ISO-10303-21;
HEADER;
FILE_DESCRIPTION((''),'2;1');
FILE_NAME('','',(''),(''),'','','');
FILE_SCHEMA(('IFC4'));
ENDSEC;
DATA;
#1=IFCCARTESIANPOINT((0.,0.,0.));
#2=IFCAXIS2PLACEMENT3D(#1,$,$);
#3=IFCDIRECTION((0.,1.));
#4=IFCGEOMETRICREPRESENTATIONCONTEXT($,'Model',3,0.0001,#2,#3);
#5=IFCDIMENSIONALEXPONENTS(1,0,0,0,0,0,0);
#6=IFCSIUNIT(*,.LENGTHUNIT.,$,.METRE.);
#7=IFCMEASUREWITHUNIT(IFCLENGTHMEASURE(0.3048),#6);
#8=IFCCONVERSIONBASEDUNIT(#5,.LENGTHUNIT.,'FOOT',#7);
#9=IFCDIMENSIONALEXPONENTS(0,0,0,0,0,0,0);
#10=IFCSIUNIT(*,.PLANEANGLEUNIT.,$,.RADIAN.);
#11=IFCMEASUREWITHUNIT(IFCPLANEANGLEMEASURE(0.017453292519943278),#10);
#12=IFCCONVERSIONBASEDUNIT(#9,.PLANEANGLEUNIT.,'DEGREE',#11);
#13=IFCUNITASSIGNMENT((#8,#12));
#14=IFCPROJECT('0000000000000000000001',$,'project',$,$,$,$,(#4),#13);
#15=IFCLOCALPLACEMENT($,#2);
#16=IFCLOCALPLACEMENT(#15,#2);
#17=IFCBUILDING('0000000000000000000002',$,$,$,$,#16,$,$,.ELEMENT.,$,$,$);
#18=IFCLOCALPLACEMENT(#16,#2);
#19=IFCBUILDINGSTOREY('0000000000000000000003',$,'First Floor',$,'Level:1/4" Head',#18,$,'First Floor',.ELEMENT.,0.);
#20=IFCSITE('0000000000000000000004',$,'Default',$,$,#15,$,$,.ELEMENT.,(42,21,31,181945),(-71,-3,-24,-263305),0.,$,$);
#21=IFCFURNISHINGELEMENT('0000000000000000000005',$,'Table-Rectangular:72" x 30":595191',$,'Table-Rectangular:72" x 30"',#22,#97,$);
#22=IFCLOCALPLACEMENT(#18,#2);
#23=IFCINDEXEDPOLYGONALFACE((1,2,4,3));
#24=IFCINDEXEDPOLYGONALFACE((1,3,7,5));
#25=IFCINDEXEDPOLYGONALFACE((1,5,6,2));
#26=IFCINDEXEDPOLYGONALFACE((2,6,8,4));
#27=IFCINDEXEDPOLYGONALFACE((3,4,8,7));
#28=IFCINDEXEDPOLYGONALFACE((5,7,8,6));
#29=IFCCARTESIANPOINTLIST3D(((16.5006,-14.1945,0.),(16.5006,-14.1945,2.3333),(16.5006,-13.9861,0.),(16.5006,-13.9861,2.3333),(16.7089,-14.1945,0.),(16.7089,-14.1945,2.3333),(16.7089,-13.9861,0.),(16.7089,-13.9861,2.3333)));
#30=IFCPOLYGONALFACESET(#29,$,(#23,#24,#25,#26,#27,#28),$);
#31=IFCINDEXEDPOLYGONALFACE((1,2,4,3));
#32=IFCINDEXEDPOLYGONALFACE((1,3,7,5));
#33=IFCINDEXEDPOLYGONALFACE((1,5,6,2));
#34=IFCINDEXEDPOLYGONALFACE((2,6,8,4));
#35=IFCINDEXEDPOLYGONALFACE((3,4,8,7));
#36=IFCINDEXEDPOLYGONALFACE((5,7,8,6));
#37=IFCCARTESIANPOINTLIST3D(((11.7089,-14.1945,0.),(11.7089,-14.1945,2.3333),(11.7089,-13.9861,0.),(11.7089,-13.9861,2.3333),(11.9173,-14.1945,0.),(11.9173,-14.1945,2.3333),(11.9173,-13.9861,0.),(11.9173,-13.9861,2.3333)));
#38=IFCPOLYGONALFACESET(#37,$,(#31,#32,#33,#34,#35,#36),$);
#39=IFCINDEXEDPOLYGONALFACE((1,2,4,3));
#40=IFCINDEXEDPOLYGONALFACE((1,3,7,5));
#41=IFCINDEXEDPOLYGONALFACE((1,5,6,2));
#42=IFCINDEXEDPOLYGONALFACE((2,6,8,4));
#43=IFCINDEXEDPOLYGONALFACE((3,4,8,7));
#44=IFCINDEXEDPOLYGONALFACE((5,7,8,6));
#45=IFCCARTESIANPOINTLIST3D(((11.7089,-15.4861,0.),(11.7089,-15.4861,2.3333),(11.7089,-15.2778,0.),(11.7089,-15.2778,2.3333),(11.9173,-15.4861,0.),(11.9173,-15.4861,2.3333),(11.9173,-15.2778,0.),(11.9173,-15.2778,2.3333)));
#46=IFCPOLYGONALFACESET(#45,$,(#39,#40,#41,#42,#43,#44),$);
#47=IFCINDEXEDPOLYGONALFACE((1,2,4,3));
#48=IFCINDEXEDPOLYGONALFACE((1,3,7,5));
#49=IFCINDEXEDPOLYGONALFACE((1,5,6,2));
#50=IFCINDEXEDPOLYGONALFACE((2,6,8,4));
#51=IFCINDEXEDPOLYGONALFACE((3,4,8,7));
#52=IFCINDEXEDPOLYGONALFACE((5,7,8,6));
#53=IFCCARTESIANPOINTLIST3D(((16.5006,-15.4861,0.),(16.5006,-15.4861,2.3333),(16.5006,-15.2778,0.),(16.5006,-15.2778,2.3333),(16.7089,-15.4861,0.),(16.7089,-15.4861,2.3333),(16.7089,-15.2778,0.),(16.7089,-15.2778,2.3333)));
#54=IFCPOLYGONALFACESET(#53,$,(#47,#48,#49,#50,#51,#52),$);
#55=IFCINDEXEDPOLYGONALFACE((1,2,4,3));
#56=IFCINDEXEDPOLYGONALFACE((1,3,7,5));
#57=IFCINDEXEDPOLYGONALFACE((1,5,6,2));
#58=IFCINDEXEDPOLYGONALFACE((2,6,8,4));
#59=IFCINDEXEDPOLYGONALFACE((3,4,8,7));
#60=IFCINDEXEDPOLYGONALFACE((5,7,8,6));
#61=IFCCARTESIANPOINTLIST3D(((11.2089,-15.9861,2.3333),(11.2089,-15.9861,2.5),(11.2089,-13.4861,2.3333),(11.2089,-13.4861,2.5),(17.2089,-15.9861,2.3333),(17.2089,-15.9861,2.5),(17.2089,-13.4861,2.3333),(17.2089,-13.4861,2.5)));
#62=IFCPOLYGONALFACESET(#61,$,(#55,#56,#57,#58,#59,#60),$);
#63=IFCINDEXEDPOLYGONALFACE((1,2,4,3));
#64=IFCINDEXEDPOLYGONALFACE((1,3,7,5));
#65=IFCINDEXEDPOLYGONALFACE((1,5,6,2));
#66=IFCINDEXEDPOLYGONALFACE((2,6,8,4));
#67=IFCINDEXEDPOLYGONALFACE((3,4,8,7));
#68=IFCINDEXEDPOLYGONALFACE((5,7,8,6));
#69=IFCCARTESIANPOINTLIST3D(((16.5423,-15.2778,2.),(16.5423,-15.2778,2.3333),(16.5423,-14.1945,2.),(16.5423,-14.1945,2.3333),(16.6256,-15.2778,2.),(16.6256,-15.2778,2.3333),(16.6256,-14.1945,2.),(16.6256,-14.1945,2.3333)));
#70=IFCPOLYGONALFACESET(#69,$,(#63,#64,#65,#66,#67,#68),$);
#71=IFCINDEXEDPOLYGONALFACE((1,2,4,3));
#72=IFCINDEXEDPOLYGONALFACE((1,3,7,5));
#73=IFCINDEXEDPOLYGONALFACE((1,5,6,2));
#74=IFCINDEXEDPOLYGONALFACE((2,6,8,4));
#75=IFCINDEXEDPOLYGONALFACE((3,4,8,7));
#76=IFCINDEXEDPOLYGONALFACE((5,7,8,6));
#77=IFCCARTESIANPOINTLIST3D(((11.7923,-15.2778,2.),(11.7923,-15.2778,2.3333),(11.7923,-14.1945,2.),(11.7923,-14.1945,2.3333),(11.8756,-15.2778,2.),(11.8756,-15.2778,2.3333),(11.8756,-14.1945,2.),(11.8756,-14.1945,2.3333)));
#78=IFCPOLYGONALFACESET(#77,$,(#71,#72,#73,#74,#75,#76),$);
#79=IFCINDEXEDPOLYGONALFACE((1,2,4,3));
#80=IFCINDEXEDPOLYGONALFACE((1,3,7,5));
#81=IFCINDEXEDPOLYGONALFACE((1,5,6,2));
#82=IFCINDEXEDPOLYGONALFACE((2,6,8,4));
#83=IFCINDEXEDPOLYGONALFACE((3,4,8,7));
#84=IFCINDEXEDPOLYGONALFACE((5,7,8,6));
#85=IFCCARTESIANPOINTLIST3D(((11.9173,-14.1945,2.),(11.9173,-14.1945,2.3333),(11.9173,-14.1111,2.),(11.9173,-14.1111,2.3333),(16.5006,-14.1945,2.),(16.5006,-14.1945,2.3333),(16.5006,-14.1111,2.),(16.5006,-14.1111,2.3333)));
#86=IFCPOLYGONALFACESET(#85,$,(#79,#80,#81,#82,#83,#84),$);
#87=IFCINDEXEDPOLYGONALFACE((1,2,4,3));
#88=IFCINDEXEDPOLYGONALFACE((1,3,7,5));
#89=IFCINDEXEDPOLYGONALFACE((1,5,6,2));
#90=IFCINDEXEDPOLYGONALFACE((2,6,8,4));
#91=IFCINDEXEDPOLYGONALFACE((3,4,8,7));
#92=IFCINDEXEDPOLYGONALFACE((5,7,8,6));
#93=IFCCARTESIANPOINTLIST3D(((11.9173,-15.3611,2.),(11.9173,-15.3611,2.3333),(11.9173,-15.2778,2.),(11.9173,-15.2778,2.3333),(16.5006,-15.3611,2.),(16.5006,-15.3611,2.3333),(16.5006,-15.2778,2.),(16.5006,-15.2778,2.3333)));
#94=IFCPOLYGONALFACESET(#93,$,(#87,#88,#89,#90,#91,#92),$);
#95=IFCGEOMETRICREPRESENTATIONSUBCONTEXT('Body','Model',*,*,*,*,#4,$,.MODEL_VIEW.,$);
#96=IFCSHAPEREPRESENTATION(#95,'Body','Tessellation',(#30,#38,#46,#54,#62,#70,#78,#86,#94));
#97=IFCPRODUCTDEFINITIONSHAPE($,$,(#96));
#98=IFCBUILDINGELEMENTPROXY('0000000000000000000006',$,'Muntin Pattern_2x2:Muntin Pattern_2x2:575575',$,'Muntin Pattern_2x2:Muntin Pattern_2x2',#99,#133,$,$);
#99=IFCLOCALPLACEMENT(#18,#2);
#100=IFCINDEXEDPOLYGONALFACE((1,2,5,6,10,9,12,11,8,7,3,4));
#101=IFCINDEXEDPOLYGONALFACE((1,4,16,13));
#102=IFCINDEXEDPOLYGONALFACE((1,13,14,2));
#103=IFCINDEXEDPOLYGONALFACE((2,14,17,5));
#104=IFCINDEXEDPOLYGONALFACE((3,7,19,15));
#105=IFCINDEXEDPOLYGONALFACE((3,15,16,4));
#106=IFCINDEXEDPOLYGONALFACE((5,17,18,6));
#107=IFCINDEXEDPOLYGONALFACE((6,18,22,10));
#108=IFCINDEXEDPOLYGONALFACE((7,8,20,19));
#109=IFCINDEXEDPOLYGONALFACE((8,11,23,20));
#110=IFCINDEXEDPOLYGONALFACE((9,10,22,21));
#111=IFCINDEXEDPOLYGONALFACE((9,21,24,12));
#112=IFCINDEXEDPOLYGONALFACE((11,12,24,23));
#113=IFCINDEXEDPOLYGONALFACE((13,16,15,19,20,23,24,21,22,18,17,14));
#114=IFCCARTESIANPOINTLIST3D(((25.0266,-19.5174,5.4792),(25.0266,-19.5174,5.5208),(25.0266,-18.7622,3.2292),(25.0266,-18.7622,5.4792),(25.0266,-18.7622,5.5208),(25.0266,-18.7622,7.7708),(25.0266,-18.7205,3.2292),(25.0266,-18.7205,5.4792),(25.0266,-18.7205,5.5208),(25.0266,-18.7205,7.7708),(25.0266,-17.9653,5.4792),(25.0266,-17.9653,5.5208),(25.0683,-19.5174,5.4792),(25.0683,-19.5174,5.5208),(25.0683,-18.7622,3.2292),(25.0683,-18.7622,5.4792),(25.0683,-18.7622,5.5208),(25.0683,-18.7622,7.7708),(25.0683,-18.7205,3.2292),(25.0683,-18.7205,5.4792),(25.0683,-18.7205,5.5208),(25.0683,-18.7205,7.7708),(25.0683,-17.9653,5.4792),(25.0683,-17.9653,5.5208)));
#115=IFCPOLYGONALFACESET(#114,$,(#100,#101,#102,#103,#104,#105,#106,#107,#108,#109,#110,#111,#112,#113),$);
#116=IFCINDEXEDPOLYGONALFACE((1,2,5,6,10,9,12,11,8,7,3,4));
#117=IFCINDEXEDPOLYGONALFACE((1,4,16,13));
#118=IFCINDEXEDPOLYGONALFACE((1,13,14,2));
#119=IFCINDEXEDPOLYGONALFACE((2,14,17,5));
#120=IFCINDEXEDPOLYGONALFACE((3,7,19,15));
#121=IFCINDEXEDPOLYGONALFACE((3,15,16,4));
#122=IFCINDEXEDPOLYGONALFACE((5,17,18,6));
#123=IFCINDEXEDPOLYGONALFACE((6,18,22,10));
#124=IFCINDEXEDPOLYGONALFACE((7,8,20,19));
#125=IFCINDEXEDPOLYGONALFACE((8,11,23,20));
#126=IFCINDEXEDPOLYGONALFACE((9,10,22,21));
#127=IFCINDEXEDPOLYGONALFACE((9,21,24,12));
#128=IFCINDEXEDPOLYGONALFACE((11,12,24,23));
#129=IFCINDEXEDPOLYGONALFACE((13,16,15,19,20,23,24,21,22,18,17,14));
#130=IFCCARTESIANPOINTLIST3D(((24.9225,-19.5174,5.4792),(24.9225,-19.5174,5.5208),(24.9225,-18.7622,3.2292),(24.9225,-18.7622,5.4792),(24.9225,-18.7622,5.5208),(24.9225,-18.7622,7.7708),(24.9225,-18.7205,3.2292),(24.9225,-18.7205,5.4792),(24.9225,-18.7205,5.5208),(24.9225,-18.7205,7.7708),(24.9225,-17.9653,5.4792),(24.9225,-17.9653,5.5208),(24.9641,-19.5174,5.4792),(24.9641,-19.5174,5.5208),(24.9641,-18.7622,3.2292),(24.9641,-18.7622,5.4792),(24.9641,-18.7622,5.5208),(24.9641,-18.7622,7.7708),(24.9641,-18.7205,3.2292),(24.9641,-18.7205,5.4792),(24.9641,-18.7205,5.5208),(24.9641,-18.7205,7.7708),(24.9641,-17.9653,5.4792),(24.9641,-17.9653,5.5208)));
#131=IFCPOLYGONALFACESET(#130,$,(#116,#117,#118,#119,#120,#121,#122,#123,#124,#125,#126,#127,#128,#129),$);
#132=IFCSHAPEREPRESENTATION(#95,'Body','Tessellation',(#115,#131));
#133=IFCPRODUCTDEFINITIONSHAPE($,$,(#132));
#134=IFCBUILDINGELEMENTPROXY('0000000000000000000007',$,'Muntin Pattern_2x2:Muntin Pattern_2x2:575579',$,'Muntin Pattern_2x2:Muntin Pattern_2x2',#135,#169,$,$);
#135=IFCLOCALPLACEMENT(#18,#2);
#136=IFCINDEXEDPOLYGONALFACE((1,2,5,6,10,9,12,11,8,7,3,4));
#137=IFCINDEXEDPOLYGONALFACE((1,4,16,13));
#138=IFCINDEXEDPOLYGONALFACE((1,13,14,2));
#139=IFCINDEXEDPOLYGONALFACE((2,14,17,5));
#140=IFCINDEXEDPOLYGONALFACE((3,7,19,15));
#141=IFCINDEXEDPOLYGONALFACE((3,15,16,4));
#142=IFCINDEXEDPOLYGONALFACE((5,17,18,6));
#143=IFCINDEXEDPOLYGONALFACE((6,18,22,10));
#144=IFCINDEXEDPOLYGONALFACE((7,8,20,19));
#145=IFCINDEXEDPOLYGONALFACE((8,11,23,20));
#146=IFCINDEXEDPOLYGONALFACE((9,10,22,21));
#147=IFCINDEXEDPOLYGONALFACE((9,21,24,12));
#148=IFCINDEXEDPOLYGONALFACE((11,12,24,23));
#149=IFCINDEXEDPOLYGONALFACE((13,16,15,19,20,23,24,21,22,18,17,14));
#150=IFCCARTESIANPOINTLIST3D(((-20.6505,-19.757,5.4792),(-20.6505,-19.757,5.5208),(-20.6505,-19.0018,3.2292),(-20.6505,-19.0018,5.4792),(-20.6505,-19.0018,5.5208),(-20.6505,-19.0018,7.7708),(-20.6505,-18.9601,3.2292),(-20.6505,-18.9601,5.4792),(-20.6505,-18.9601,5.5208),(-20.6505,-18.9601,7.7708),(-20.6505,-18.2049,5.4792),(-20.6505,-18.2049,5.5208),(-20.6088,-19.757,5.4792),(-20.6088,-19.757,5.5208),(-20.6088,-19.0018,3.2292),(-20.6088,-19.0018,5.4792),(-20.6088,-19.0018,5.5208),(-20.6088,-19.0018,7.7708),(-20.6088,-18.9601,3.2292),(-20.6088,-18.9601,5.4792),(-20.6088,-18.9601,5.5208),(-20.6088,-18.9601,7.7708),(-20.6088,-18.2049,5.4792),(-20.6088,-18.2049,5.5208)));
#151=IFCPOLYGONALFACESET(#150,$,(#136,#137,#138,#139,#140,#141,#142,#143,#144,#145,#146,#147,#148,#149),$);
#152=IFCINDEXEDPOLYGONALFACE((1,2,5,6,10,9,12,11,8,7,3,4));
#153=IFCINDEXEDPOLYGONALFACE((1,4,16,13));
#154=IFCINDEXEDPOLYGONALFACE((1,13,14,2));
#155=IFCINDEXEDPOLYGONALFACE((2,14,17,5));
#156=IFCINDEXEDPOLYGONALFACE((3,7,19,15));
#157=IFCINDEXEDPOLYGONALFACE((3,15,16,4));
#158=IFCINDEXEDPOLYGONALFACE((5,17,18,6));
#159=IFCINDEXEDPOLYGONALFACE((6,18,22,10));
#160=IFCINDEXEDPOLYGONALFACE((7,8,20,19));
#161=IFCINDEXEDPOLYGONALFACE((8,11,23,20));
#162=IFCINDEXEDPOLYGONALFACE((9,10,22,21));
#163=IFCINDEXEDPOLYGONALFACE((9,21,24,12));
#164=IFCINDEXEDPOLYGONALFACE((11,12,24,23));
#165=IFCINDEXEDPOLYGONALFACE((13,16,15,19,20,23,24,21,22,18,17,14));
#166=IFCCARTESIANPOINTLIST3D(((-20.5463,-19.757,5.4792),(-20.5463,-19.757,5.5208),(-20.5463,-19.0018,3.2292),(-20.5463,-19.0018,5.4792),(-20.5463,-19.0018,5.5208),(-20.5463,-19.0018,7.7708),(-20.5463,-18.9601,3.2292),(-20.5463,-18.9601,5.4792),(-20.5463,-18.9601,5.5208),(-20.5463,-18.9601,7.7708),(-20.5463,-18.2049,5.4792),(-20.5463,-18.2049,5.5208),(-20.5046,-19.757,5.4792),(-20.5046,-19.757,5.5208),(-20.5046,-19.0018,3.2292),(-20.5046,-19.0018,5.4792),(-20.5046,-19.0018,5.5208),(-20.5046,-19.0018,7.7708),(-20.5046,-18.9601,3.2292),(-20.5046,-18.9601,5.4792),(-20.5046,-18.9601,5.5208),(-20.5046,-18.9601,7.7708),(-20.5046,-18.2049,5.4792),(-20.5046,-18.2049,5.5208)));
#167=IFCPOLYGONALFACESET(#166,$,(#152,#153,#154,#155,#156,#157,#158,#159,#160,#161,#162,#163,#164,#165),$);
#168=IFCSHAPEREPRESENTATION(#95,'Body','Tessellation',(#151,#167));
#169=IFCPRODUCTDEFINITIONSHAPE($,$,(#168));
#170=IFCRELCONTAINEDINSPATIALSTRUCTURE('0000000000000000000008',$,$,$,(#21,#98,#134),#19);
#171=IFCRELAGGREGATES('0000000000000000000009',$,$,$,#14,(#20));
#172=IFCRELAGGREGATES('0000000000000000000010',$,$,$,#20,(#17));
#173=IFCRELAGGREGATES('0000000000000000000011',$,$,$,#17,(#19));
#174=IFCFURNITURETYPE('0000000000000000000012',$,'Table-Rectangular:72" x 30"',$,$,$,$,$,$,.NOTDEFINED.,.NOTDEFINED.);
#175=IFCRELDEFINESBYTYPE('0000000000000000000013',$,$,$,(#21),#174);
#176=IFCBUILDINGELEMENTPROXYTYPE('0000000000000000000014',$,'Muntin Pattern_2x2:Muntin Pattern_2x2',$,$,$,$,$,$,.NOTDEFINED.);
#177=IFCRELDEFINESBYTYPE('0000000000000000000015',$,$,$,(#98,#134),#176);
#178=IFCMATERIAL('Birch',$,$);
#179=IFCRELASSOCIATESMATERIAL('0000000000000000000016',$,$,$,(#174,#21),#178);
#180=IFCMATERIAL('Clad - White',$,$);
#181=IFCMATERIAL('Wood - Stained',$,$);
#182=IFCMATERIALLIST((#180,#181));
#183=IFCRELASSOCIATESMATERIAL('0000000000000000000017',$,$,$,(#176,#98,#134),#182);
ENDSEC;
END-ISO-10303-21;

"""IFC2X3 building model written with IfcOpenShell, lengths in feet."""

from ifc_helpers import new_model, entity, si_unit, converted_unit, direction, frame, frame_2d, origin, origin_2d_with_axis, place, context, subcontext, project, spatial, polyline, rectangle, outline, extrude, source, transform, mapped, material, material_list, type_object, type_shapes, element, save


model = new_model("IFC2X3")

# Units and contexts
model_context = context("Model", 3, precision=0.0001, world=origin(), true_north=direction((0.0, 1.0)))
body_context = subcontext(model_context, "Body", "Model", "MODEL_VIEW")
ifc_project = project(units=[converted_unit("LENGTHUNIT", "FOOT", entity("IfcLengthMeasure", 0.3048), si_unit("LENGTHUNIT", "METRE"), dimensions=[1, 0, 0, 0, 0, 0, 0]), converted_unit("PLANEANGLEUNIT", "DEGREE", entity("IfcPlaneAngleMeasure", 0.017453292519943278), si_unit("PLANEANGLEUNIT", "RADIAN"), dimensions=[0, 0, 0, 0, 0, 0, 0])], contexts=[model_context])

# Site, building, storey
site_placement = place(None, origin())
site = spatial("IfcSite", under=ifc_project, at=site_placement, Name="Default", CompositionType="ELEMENT", RefLatitude=(42, 21, 31, 181945), RefLongitude=(-71, -3, -24, -263305), RefElevation=0.0)
building_placement = place(site_placement, origin())
building = spatial("IfcBuilding", under=site, at=building_placement, CompositionType="ELEMENT")
storey_placement = place(building_placement, origin())
storey = spatial("IfcBuildingStorey", under=building, at=storey_placement, Name="First Floor", ObjectType="Level:1/4\" Head", LongName="First Floor", CompositionType="ELEMENT", Elevation=0.0)

# Furnishing element
ifc_material_1 = material(Name="Birch")
furniture_type_1 = type_object("IfcFurnitureType", Name="Table-Rectangular:72\" x 30\"", AssemblyPlace="NOTDEFINED", material=ifc_material_1)
shared_shape_1 = source(origin(), body_context, "Body", "SweptSolid", [
    extrude(rectangle(XDim=0.2083, YDim=0.2083, at=origin_2d_with_axis()), frame((2.3958, 0.6458, 0.0), z_axis=(0.0, 0.0, 1.0), x_axis=(0.0, -1.0, 0.0)), (0.0, 0.0, 1.0), 2.3333),
    extrude(rectangle(XDim=0.2083, YDim=0.2083, at=origin_2d_with_axis()), frame((-2.3958, 0.6458, 0.0), z_axis=(0.0, 0.0, 1.0), x_axis=(-1.0, 0.0, 0.0)), (0.0, 0.0, 1.0), 2.3333),
    extrude(rectangle(XDim=0.2083, YDim=0.2083, at=origin_2d_with_axis()), frame((-2.3958, -0.6458, 0.0), z_axis=(0.0, 0.0, 1.0), x_axis=(0.0, 1.0, 0.0)), (0.0, 0.0, 1.0), 2.3333),
    extrude(rectangle(XDim=0.2083, YDim=0.2083, at=origin_2d_with_axis()), frame((2.3958, -0.6458, 0.0)), (0.0, 0.0, 1.0), 2.3333),
    extrude(rectangle(XDim=6.0, YDim=2.5, at=origin_2d_with_axis()), frame((0.0, 0.0, 2.3333), z_axis=(0.0, 0.0, 1.0), x_axis=(-1.0, 0.0, 0.0)), (0.0, 0.0, 1.0), 0.1667),
    extrude(rectangle(XDim=0.0833, YDim=1.0833, at=origin_2d_with_axis()), frame((2.375, 0.0, 2.0)), (0.0, 0.0, 1.0), 0.3333),
    extrude(rectangle(XDim=1.0833, YDim=0.0833, at=origin_2d_with_axis()), frame((-2.375, 0.0, 2.0), z_axis=(0.0, 0.0, 1.0), x_axis=(0.0, 1.0, 0.0)), (0.0, 0.0, 1.0), 0.3333),
    extrude(rectangle(XDim=4.5833, YDim=0.0833, at=frame_2d((0.0, 0.0), x_axis=(1.0, 0.0))), frame((0.0, 0.5833, 2.0), z_axis=(0.0, 0.0, 1.0), x_axis=(-1.0, 0.0, 0.0)), (0.0, 0.0, 1.0), 0.3333),
    extrude(rectangle(XDim=0.0833, YDim=4.5833, at=origin_2d_with_axis()), frame((0.0, -0.5833, 2.0), z_axis=(0.0, 0.0, 1.0), x_axis=(0.0, 1.0, 0.0)), (0.0, 0.0, 1.0), 0.3333),
])
type_shapes(furniture_type_1, [shared_shape_1])
furnishing_1_placement = place(storey_placement, frame((14.2089, -14.7361, 0.0)))
element("IfcFurnishingElement", 1, at=furnishing_1_placement, inside=storey, type_object=furniture_type_1, material=ifc_material_1, Name="Table-Rectangular:72\" x 30\":595191", ObjectType="Table-Rectangular:72\" x 30\"", context=body_context, shape_type="MappedRepresentation", body=[
    mapped(shared_shape_1, transform((0.0, 0.0, 0.0), scale=1.0)),
])

# Building element proxies
ifc_material_2 = material(Name="Clad - White")
ifc_material_3 = material(Name="Wood - Stained")
ifc_material_list_1 = material_list([ifc_material_2, ifc_material_3])
building_element_proxy_type_1 = type_object("IfcBuildingElementProxyType", Name="Muntin Pattern_2x2:Muntin Pattern_2x2", PredefinedType="NOTDEFINED", material=ifc_material_list_1)
shared_shape_2 = source(origin(), body_context, "Body", "SweptSolid", [
    extrude(outline(polyline([(0.0208, -0.0208), (2.2708, -0.0208), (2.2708, 0.0208), (0.0208, 0.0208), (0.0208, 0.776), (-0.0208, 0.776), (-0.0208, 0.0208), (-2.2708, 0.0208), (-2.2708, -0.0208), (-0.0208, -0.0208), (-0.0208, -0.776), (0.0208, -0.776), (0.0208, -0.0208)])), frame((0.0, 0.0313, 2.2708), z_axis=(0.0, 1.0, 0.0), x_axis=(0.0, 0.0, 1.0)), (0.0, 0.0, 1.0), 0.0417),
    extrude(outline(polyline([(0.0208, -0.0208), (2.2708, -0.0208), (2.2708, 0.0208), (0.0208, 0.0208), (0.0208, 0.776), (-0.0208, 0.776), (-0.0208, 0.0208), (-2.2708, 0.0208), (-2.2708, -0.0208), (-0.0208, -0.0208), (-0.0208, -0.776), (0.0208, -0.776), (0.0208, -0.0208)])), frame((0.0, -0.0729, 2.2708), z_axis=(0.0, 1.0, 0.0), x_axis=(0.0, 0.0, 1.0)), (0.0, 0.0, 1.0), 0.0417),
])
type_shapes(building_element_proxy_type_1, [shared_shape_2])
for number, where, z_axis, x_axis, name in (
    (2, (24.9954, -18.7413, 3.2292), (0.0, 0.0, 1.0), (0.0, -1.0, 0.0), "Muntin Pattern_2x2:Muntin Pattern_2x2:575575"),
    (3, (-20.5775, -18.9809, 3.2292), (0.0, 0.0, 1.0), (0.0, 1.0, 0.0), "Muntin Pattern_2x2:Muntin Pattern_2x2:575579"),
):
    element("IfcBuildingElementProxy", number, at=place(storey_placement, frame(where, z_axis=z_axis, x_axis=x_axis)), inside=storey, type_object=building_element_proxy_type_1, material=ifc_material_list_1, Name=name, ObjectType="Muntin Pattern_2x2:Muntin Pattern_2x2", context=body_context, shape_type="MappedRepresentation", body=[
        mapped(shared_shape_2, transform((0.0, 0.0, 0.0), scale=1.0)),
    ])

save(model, "model.ifc")
